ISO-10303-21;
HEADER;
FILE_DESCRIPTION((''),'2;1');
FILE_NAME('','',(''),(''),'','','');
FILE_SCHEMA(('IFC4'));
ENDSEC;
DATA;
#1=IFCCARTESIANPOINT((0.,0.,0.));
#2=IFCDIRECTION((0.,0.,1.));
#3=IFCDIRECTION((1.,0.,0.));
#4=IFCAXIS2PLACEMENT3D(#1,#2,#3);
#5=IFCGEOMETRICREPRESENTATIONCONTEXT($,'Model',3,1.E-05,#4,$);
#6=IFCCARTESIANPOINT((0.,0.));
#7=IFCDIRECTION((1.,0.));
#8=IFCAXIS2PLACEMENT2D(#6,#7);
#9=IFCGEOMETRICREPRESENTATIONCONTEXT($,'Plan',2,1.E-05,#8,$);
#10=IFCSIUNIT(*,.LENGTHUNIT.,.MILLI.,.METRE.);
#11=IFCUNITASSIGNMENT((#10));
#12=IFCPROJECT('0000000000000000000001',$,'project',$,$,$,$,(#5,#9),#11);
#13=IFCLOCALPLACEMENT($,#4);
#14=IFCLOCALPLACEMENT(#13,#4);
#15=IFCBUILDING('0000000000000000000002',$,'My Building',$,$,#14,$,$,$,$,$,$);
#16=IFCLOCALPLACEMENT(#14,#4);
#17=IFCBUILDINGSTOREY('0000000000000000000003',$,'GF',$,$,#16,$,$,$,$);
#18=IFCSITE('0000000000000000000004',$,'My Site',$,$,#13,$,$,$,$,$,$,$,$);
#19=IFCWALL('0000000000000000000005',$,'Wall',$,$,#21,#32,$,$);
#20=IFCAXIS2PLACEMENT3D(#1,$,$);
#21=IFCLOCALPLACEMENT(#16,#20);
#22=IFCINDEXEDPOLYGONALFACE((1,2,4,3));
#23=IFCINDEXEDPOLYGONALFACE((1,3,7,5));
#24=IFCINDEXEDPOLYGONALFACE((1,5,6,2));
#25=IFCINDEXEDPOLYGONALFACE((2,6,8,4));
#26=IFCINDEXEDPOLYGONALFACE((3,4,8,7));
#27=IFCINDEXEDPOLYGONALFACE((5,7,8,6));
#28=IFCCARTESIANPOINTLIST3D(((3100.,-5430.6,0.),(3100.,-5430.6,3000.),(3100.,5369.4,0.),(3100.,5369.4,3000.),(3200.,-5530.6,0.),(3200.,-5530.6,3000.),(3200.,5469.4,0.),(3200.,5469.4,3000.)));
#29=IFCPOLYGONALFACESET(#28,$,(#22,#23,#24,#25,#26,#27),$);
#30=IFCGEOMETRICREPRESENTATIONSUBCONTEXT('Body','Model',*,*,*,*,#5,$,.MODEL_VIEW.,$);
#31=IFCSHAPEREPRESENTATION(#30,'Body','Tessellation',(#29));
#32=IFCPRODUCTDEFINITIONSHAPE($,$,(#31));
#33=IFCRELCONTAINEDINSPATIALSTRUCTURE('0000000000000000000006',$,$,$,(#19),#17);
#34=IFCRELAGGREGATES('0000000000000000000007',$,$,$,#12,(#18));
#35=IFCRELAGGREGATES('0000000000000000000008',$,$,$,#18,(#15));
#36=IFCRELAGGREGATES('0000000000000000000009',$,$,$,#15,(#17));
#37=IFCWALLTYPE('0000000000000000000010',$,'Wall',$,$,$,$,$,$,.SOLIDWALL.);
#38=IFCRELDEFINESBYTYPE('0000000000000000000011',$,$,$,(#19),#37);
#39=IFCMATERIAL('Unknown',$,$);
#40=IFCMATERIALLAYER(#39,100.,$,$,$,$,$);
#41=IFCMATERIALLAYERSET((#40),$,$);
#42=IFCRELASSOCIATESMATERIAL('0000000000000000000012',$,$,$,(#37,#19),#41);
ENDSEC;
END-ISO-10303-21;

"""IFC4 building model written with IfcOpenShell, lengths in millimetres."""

from ifc_helpers import new_model, si_unit, frame, origin_with_axes, origin_2d_with_axis, place, context, subcontext, project, spatial, line, indexed_curve, outline, extrude, material, layer, layer_set, layer_usage, type_object, element, save


model = new_model("IFC4")

# Units and contexts
model_context = context("Model", 3, precision=1e-05, world=origin_with_axes())
plan_context = context("Plan", 2, precision=1e-05, world=origin_2d_with_axis())
body_context_1 = subcontext(model_context, "Body", "Model", "MODEL_VIEW")
ifc_project = project(units=[si_unit("LENGTHUNIT", "METRE", prefix="MILLI")], contexts=[model_context, plan_context])

# Site, building, storey
site_placement = place(None, origin_with_axes())
site = spatial("IfcSite", under=ifc_project, at=site_placement, Name="My Site")
building_placement = place(site_placement, origin_with_axes())
building = spatial("IfcBuilding", under=site, at=building_placement, Name="My Building")
storey_placement = place(building_placement, origin_with_axes())
storey = spatial("IfcBuildingStorey", under=building, at=storey_placement, Name="GF")

# Shared definitions
ifc_material = material(Name="Unknown")

# Shared definitions
ifc_layer_1 = layer(ifc_material, 100.0)
ifc_layer_set_1 = layer_set([ifc_layer_1])
wall_type = type_object("IfcWallType", Name="Wall", PredefinedType="SOLIDWALL", material=ifc_layer_set_1)

# Wall
ifc_layer_usage_1 = layer_usage(ifc_layer_set_1, "AXIS2", "POSITIVE", 0.0)
wall_1_placement = place(storey_placement, frame((3100.0, 5369.4, 0.0), z_axis=(0.0, 0.0, 1.0), x_axis=(0.0, -1.0, 0.0)))
element("IfcWall", 1, at=wall_1_placement, inside=storey, type_object=wall_type, material=ifc_layer_usage_1, Name="Wall", context=body_context_1, shape_type="SweptSolid", body=[
    extrude(outline(indexed_curve([(0.0, 0.0), (-100.0, 100.0), (10900.0, 100.0), (10800.0, 0.0)], segments=[line(1, 2, 3, 4, 1)])), origin_with_axes(), (0.0, 0.0, 1.0), 3000.0),
])

save(model, "model.ifc")
